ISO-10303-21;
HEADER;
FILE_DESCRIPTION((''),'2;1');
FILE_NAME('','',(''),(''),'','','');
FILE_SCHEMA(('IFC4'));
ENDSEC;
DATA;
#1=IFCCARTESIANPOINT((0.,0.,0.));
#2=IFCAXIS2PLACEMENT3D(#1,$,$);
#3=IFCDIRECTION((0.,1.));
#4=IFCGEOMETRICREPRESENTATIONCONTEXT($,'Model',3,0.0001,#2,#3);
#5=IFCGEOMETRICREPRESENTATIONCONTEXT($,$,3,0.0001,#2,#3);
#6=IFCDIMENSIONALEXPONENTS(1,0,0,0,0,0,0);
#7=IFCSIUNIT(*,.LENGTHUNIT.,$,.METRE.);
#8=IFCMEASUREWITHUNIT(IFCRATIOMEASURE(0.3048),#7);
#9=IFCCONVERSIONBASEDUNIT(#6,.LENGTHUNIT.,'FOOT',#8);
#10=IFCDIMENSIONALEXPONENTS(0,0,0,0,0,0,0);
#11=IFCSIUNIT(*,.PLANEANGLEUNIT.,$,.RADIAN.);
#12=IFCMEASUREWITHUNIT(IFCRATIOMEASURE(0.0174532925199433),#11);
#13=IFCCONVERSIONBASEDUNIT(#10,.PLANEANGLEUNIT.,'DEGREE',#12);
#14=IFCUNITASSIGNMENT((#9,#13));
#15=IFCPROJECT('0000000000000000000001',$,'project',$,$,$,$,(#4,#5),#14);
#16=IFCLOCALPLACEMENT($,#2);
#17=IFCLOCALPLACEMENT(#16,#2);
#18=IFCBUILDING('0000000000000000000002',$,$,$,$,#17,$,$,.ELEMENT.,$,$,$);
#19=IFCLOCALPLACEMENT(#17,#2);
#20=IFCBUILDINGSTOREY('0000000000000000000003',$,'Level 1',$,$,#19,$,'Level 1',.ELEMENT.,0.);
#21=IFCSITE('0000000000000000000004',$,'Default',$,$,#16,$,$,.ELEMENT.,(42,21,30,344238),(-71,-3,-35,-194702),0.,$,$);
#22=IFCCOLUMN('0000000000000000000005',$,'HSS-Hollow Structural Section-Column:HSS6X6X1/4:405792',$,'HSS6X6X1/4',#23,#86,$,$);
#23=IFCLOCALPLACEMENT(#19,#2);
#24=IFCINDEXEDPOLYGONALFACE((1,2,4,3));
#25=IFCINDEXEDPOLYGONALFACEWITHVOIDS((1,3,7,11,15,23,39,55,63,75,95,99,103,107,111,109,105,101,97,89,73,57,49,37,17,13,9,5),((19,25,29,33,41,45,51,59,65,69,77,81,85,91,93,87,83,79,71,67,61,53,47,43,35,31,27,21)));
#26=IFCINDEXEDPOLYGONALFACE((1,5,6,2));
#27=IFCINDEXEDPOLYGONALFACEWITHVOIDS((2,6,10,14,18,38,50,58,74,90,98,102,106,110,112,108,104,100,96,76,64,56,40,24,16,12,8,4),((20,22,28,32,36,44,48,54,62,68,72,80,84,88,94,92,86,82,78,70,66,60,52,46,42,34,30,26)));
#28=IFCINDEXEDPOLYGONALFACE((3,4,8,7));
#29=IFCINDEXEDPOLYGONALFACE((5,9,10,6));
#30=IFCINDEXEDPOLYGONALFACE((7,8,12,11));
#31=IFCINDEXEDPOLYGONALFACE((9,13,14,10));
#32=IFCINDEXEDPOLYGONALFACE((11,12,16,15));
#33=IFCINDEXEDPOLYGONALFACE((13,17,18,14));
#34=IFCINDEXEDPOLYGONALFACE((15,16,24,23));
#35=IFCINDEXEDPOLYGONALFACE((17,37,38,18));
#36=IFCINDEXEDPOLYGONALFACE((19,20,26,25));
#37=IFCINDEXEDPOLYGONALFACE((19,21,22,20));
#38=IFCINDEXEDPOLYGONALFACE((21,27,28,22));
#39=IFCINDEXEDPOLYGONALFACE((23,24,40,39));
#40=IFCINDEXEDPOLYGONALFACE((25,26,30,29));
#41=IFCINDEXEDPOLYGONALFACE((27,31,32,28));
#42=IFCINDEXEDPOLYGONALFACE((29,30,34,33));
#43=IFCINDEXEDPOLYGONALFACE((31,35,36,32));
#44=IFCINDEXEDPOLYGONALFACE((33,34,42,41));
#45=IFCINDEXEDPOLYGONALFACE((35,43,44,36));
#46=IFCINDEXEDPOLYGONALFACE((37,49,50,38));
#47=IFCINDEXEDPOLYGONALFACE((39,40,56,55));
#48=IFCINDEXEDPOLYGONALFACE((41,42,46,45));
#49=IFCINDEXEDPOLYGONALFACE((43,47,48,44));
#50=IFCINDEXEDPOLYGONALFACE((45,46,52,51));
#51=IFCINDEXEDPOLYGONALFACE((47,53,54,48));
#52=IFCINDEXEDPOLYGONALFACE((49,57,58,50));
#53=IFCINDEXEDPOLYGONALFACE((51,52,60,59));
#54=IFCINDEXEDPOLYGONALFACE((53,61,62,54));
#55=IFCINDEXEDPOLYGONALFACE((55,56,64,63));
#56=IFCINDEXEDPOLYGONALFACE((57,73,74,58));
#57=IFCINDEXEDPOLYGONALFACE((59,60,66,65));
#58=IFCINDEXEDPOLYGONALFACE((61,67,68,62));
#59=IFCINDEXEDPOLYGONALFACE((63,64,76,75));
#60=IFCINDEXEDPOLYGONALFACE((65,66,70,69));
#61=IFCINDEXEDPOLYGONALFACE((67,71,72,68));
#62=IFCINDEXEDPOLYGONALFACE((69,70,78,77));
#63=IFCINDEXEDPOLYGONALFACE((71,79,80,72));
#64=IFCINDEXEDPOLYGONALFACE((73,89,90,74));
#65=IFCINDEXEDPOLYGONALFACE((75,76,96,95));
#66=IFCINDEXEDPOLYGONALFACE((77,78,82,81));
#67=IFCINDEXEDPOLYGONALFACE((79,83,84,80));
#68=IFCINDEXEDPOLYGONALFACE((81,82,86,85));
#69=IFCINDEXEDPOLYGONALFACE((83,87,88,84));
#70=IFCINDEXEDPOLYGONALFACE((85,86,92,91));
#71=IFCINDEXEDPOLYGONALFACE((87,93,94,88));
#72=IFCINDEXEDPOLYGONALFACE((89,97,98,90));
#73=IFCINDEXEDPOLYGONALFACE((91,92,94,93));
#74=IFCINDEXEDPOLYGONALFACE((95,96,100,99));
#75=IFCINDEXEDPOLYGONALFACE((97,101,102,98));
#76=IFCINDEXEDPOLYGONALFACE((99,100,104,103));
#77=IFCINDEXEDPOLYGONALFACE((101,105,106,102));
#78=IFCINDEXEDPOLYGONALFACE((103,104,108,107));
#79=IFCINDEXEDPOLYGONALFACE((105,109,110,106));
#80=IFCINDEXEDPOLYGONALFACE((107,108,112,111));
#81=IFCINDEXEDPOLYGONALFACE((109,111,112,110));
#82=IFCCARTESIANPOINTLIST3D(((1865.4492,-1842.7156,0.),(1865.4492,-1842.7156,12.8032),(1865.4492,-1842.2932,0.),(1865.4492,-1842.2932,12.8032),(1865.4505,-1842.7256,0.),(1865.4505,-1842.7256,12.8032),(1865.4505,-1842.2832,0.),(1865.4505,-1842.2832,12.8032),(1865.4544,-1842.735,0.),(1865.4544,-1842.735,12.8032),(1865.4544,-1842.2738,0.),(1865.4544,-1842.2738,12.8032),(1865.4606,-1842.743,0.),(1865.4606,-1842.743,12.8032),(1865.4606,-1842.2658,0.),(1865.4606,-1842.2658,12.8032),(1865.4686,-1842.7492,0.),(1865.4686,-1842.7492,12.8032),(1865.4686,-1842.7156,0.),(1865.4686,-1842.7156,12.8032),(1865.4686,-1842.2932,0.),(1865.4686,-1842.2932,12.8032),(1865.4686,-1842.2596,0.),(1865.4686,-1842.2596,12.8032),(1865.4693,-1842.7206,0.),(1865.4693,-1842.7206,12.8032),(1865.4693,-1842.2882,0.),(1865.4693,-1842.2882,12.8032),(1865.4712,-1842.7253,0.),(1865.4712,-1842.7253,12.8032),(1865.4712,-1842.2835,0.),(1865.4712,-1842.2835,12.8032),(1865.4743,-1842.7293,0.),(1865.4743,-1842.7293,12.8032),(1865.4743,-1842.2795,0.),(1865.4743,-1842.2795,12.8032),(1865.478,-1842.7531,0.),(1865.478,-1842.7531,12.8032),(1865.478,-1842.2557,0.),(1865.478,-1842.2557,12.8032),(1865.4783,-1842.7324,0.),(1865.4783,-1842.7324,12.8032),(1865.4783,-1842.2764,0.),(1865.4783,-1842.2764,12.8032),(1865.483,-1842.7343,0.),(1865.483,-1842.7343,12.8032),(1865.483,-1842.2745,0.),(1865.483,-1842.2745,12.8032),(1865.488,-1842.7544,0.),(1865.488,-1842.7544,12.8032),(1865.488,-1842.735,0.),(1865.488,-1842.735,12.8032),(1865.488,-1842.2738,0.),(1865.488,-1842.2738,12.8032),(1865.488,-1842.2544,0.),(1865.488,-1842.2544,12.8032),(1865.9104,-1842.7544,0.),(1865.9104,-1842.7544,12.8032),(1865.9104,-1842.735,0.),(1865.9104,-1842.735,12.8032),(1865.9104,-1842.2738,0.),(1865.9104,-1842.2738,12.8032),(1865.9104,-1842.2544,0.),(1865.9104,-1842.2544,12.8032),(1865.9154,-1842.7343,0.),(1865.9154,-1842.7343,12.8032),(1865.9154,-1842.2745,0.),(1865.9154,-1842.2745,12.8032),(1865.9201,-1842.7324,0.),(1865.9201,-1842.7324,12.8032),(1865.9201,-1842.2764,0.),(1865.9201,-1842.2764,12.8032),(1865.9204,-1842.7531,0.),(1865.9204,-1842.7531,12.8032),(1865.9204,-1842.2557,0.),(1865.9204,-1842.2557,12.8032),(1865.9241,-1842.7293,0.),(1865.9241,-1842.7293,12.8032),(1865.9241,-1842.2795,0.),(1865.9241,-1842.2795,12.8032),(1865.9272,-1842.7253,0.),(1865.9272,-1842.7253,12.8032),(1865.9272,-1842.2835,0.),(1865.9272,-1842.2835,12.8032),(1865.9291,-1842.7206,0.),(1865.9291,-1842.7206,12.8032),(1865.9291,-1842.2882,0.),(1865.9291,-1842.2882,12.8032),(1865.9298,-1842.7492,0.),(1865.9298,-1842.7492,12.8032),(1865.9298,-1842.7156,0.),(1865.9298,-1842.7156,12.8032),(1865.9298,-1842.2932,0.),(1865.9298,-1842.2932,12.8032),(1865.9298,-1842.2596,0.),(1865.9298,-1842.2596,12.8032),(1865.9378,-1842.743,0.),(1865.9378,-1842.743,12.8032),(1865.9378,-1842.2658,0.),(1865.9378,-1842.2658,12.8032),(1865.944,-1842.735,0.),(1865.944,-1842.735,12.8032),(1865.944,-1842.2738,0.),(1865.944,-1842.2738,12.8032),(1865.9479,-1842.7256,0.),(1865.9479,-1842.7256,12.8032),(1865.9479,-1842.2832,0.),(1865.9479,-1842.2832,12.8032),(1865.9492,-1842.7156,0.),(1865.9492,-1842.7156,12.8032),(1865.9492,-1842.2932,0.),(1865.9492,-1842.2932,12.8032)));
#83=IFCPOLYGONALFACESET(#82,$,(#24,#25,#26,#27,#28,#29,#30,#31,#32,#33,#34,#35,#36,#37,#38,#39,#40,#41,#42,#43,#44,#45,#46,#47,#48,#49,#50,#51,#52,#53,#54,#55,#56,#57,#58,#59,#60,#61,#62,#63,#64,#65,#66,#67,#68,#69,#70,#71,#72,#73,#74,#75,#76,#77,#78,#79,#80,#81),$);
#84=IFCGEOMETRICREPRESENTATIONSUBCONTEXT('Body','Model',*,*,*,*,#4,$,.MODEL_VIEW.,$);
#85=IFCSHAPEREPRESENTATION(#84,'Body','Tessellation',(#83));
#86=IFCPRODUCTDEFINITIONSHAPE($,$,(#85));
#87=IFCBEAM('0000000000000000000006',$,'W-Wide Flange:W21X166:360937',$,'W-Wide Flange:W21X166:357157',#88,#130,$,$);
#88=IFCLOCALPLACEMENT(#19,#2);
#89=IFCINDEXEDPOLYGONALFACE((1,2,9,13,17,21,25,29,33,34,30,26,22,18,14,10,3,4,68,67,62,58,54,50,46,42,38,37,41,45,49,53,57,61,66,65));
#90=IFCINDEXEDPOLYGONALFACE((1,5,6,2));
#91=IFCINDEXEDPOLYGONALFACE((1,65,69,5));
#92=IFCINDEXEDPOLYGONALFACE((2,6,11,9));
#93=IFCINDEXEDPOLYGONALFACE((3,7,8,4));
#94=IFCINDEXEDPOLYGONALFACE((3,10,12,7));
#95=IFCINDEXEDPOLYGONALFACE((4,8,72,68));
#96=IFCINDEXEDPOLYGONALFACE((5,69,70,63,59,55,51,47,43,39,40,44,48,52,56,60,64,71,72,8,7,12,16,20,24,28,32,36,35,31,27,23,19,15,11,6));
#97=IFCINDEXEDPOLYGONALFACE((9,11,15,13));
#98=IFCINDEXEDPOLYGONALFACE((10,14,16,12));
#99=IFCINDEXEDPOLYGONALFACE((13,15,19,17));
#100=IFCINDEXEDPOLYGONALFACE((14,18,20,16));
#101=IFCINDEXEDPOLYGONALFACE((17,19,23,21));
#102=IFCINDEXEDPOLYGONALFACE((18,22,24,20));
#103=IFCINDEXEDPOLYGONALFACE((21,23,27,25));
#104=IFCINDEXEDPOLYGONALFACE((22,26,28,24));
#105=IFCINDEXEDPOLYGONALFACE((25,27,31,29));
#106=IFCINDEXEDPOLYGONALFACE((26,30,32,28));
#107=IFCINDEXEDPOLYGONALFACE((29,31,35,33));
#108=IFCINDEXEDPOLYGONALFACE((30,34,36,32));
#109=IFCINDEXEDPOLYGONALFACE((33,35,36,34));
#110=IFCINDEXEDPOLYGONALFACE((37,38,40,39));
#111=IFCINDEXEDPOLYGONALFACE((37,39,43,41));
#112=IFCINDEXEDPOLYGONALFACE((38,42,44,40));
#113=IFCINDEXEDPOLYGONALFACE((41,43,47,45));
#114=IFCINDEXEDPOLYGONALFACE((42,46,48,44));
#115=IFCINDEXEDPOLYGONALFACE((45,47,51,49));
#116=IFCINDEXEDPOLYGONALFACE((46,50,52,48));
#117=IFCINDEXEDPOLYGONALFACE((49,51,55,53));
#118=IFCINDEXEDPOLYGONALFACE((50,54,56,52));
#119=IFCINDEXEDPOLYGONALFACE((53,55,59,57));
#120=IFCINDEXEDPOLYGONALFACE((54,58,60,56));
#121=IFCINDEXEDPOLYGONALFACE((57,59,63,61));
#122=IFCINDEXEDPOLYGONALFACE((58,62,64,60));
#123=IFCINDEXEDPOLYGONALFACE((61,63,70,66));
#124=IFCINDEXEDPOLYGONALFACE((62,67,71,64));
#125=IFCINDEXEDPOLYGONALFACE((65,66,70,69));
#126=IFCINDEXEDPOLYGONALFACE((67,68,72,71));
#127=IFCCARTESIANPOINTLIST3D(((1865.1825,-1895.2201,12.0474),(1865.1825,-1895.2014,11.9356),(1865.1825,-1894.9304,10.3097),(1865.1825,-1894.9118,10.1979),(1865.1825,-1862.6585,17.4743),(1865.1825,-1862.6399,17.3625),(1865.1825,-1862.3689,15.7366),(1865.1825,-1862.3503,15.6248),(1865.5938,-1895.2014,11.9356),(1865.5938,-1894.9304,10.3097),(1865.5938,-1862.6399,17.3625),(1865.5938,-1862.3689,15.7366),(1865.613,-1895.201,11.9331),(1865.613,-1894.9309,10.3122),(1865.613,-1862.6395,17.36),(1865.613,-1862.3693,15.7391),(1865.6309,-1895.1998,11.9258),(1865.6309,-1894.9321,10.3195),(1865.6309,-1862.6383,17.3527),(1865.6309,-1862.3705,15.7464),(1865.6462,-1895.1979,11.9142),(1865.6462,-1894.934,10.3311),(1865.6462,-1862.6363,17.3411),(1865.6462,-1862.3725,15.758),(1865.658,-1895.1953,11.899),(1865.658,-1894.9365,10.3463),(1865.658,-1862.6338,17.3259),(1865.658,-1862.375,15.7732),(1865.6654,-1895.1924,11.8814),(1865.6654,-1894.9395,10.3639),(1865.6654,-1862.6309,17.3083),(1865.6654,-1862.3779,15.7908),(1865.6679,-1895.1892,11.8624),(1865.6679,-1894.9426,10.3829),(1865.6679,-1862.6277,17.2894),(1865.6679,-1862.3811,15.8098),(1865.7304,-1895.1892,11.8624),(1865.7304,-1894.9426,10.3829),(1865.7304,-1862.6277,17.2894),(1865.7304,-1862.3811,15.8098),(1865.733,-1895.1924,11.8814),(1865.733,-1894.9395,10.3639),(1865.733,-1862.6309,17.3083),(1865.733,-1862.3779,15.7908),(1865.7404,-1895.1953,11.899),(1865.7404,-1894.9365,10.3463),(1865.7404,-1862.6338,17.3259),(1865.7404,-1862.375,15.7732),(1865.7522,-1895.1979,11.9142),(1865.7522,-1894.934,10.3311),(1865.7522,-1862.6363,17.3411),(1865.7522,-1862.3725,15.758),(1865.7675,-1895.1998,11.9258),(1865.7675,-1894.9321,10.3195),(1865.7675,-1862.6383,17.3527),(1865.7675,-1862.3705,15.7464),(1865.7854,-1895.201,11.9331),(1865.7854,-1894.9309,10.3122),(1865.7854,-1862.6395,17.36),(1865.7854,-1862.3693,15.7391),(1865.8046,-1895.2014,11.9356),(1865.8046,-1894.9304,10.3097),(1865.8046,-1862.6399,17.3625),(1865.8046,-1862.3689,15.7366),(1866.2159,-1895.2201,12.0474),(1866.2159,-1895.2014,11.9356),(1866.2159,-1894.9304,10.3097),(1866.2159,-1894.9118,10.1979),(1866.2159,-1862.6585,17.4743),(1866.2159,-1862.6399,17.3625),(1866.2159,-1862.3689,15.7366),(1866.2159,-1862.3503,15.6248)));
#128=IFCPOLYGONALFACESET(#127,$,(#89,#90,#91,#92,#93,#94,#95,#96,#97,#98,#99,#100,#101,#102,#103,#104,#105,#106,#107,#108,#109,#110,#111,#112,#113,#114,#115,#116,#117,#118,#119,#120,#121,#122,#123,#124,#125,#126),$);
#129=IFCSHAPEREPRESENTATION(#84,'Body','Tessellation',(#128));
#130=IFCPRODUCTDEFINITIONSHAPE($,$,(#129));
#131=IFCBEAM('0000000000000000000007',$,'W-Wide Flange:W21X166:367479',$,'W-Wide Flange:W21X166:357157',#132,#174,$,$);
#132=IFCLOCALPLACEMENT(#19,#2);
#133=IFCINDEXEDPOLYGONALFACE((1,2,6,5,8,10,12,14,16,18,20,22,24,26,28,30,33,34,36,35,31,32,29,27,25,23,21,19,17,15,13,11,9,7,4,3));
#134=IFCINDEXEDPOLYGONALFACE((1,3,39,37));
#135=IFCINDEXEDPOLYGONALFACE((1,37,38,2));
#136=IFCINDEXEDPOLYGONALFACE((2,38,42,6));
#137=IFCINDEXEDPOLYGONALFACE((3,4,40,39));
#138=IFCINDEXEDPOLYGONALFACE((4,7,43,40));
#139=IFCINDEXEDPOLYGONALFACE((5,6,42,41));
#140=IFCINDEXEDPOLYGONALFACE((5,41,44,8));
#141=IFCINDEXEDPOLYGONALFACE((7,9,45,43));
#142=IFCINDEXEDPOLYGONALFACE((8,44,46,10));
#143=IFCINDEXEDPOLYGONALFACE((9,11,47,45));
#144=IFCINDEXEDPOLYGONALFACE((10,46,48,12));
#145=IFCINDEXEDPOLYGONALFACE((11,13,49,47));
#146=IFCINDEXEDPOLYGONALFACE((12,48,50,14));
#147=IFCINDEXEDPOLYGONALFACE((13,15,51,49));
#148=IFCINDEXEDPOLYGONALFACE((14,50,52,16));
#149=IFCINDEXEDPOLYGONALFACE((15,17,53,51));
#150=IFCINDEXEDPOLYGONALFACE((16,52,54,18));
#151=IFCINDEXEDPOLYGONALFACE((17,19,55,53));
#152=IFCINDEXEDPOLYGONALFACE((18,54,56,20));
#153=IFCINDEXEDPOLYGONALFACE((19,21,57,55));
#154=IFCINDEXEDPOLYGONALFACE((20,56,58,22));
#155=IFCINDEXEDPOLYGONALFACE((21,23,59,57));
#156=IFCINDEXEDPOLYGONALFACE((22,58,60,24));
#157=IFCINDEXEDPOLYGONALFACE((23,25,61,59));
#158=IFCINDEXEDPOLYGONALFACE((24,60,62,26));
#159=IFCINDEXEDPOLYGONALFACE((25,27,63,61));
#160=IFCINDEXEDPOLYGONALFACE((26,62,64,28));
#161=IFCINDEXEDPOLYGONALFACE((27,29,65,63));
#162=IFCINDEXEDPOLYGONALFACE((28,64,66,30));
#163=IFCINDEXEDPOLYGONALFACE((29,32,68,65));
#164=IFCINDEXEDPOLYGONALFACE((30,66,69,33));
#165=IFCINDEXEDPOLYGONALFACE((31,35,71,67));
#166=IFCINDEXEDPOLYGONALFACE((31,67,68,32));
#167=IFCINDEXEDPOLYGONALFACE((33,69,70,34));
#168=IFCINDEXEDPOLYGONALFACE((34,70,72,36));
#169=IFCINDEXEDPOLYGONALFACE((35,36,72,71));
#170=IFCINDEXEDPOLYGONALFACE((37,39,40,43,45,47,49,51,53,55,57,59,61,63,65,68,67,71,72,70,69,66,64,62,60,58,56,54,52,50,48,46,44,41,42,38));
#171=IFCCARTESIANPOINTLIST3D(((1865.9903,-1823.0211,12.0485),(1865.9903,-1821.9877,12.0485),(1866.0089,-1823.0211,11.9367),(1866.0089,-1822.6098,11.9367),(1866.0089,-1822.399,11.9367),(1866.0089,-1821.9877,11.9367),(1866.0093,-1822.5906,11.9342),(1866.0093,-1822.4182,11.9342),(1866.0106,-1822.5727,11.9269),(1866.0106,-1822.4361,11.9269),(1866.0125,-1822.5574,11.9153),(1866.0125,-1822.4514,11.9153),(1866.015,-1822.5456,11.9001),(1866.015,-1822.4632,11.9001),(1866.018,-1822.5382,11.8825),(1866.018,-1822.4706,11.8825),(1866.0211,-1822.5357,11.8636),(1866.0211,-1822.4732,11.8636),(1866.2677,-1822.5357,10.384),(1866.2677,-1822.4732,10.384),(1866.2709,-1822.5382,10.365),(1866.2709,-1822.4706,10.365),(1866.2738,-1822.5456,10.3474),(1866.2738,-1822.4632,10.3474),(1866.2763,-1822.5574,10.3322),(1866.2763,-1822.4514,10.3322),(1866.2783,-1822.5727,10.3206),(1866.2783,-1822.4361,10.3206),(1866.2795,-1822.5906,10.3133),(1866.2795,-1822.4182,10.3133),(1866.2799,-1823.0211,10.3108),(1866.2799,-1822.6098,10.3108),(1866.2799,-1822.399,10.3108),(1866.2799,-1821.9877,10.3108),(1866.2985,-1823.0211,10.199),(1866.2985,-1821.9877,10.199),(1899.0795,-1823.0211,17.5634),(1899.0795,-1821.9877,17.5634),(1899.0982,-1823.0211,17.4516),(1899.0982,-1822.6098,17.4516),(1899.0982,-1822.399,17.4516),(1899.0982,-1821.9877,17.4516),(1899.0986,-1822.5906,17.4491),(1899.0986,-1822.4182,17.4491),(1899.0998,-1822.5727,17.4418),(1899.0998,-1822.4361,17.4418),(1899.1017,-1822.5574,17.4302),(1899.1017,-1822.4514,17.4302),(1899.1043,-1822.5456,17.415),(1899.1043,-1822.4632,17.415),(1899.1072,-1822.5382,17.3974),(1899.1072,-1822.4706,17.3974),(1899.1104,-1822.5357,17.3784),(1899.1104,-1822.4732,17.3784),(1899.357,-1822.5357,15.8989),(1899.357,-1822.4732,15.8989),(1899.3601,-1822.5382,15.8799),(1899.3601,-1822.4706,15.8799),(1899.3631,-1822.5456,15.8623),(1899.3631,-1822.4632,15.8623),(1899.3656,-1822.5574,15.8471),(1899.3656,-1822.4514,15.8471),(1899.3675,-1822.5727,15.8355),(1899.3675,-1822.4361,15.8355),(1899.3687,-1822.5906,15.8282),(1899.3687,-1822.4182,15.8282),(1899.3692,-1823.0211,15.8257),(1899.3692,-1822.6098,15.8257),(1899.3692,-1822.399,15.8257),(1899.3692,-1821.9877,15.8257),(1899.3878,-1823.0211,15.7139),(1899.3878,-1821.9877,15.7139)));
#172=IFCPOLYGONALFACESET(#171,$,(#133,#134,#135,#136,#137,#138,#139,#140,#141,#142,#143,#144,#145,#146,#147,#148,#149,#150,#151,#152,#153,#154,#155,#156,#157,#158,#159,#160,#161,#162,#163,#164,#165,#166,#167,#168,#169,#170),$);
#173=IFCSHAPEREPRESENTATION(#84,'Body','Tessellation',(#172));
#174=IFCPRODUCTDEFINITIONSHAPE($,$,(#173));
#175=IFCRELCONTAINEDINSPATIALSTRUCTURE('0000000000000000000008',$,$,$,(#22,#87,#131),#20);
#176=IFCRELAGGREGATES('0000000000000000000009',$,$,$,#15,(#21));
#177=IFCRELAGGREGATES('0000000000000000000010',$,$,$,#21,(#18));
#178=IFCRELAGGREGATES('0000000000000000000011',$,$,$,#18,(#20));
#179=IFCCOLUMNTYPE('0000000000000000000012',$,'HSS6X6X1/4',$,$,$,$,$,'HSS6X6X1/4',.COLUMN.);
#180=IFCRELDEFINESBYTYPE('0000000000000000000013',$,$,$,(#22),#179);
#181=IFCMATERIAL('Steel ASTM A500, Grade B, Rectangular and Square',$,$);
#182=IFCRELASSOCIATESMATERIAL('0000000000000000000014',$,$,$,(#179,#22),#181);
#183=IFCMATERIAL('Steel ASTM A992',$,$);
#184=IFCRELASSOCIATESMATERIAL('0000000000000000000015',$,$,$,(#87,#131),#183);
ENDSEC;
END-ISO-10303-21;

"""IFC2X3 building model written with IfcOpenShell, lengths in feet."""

from ifc_helpers import new_model, entity, si_unit, converted_unit, direction, frame, frame_2d, origin, place, context, subcontext, project, spatial, polyline, circle_curve, parameter, trimmed, segment, composite_curve, i_section, outline, extrude, source, transform, mapped, material, type_object, type_shapes, element, save


model = new_model("IFC2X3")

# Units and contexts
model_context = context("Model", 3, precision=0.0001, world=origin(), true_north=direction((0.0, 1.0)))
context_of_model = context(None, 3, precision=0.0001, world=origin(), true_north=direction((0.0, 1.0)))
body_context = subcontext(model_context, "Body", "Model", "MODEL_VIEW")
ifc_project = project(units=[converted_unit("LENGTHUNIT", "FOOT", entity("IfcRatioMeasure", 0.3048), si_unit("LENGTHUNIT", "METRE"), dimensions=[1, 0, 0, 0, 0, 0, 0]), converted_unit("PLANEANGLEUNIT", "DEGREE", entity("IfcRatioMeasure", 0.0174532925199433), si_unit("PLANEANGLEUNIT", "RADIAN"), dimensions=[0, 0, 0, 0, 0, 0, 0])], contexts=[model_context, context_of_model])

# Site, building, storey
site_placement = place(None, origin())
site = spatial("IfcSite", under=ifc_project, at=site_placement, Name="Default", CompositionType="ELEMENT", RefLatitude=(42, 21, 30, 344238), RefLongitude=(-71, -3, -35, -194702), RefElevation=0.0)
building_placement = place(site_placement, origin())
building = spatial("IfcBuilding", under=site, at=building_placement, CompositionType="ELEMENT")
storey_placement = place(building_placement, origin())
storey = spatial("IfcBuildingStorey", under=building, at=storey_placement, Name="Level 1", LongName="Level 1", CompositionType="ELEMENT", Elevation=0.0)

# Column
ifc_material_1 = material(Name="Steel ASTM A500, Grade B, Rectangular and Square")
ifc_material_2 = material(Name="Steel ASTM A992")
column_type_1 = type_object("IfcColumnType", Name="HSS6X6X1/4", ElementType="HSS6X6X1/4", PredefinedType="COLUMN", material=ifc_material_1)
shared_shape_1 = source(origin(), body_context, "Body", "SweptSolid", [
    extrude(outline(composite_curve([segment(polyline([(-0.2112, -0.25), (0.2112, -0.25)]), True, "CONTINUOUS"), segment(trimmed(circle_curve(frame_2d((0.2112, -0.2112), x_axis=(-1.0, 0.0)), 0.0388), [parameter(90.0)], [parameter(180.0)], True, "PARAMETER"), True, "CONTINUOUS"), segment(polyline([(0.25, -0.2112), (0.25, 0.2112)]), True, "CONTINUOUS"), segment(trimmed(circle_curve(frame_2d((0.2112, 0.2112), x_axis=(-1.0, 0.0)), 0.0388), [parameter(180.0)], [parameter(270.0)], True, "PARAMETER"), True, "CONTINUOUS"), segment(polyline([(0.2112, 0.25), (-0.2112, 0.25)]), True, "CONTINUOUS"), segment(trimmed(circle_curve(frame_2d((-0.2112, 0.2112), x_axis=(-1.0, 0.0)), 0.0388), [parameter(270.0)], [parameter(360.0)], True, "PARAMETER"), True, "CONTINUOUS"), segment(polyline([(-0.25, 0.2112), (-0.25, -0.2112)]), True, "CONTINUOUS"), segment(trimmed(circle_curve(frame_2d((-0.2112, -0.2112), x_axis=(-1.0, 0.0)), 0.0388), [parameter(360.0)], [parameter(90.0)], True, "PARAMETER"), True, "CONTINUOUS")], self_intersect=False), holes=[composite_curve([segment(trimmed(circle_curve(frame_2d((-0.2112, -0.2112), x_axis=(-1.0, 0.0)), 0.0194), [parameter(0.0)], [parameter(90.0)], True, "PARAMETER"), False, "CONTINUOUS"), segment(polyline([(-0.2306, -0.2112), (-0.2306, 0.2112)]), True, "CONTINUOUS"), segment(trimmed(circle_curve(frame_2d((-0.2112, 0.2112), x_axis=(-1.0, 0.0)), 0.0194), [parameter(270.0)], [parameter(360.0)], True, "PARAMETER"), False, "CONTINUOUS"), segment(polyline([(-0.2112, 0.2306), (0.2112, 0.2306)]), True, "CONTINUOUS"), segment(trimmed(circle_curve(frame_2d((0.2112, 0.2112), x_axis=(-1.0, 0.0)), 0.0194), [parameter(180.0)], [parameter(270.0)], True, "PARAMETER"), False, "CONTINUOUS"), segment(polyline([(0.2306, 0.2112), (0.2306, -0.2112)]), True, "CONTINUOUS"), segment(trimmed(circle_curve(frame_2d((0.2112, -0.2112), x_axis=(-1.0, 0.0)), 0.0194), [parameter(90.0)], [parameter(180.0)], True, "PARAMETER"), False, "CONTINUOUS"), segment(polyline([(0.2112, -0.2306), (-0.2112, -0.2306)]), True, "CONTINUOUS")], self_intersect=False)]), frame((1865.6992, -1842.5044, 0.0)), (0.0, 0.0, 1.0), 12.8032),
])
type_shapes(column_type_1, [shared_shape_1])
column_1_placement = place(storey_placement, origin())
element("IfcColumn", 1, at=column_1_placement, inside=storey, type_object=column_type_1, material=ifc_material_1, Name="HSS-Hollow Structural Section-Column:HSS6X6X1/4:405792", ObjectType="HSS6X6X1/4", context=body_context, shape_type="MappedRepresentation", body=[
    mapped(shared_shape_1, transform((0.0, 0.0, 0.0), scale=1.0)),
])

# Beams
beam_1_placement = place(storey_placement, frame((1865.6992, -1895.6585, 11.9743), z_axis=(0.0, -0.164399, 0.986394), x_axis=(0.0, 0.986394, 0.164399)))
element("IfcBeam", 2, at=beam_1_placement, inside=storey, material=ifc_material_2, Name="W-Wide Flange:W21X166:360937", ObjectType="W-Wide Flange:W21X166:357157", context=body_context, shape_type="SweptSolid", body=[
    extrude(i_section(OverallWidth=1.0333, OverallDepth=1.875, WebThickness=0.0625, FlangeThickness=0.1133, FilletRadius=0.0742, at=frame_2d((0.0, 0.0), x_axis=(0.0, 1.0))), frame((0.4445, 0.0, -0.9375), z_axis=(1.0, 0.0, 0.0), x_axis=(0.0, 0.0, -1.0)), (0.0, 0.0, 1.0), 33.0107),
])
beam_2_placement = place(storey_placement, frame((1865.8276, -1822.5044, 12.0214), z_axis=(-0.164399, 0.0, 0.986394), x_axis=(0.986394, 0.0, 0.164399)))
element("IfcBeam", 3, at=beam_2_placement, inside=storey, material=ifc_material_2, Name="W-Wide Flange:W21X166:367479", ObjectType="W-Wide Flange:W21X166:357157", context=body_context, shape_type="SweptSolid", body=[
    extrude(i_section(OverallWidth=1.0333, OverallDepth=1.875, WebThickness=0.0625, FlangeThickness=0.1133, FilletRadius=0.0742, at=frame_2d((0.0, 0.0), x_axis=(0.0, 1.0))), frame((0.165, 0.0, -0.9375), z_axis=(1.0, 0.0, 0.0), x_axis=(0.0, 0.0, -1.0)), (0.0, 0.0, 1.0), 33.5457),
])

save(model, "model.ifc")
